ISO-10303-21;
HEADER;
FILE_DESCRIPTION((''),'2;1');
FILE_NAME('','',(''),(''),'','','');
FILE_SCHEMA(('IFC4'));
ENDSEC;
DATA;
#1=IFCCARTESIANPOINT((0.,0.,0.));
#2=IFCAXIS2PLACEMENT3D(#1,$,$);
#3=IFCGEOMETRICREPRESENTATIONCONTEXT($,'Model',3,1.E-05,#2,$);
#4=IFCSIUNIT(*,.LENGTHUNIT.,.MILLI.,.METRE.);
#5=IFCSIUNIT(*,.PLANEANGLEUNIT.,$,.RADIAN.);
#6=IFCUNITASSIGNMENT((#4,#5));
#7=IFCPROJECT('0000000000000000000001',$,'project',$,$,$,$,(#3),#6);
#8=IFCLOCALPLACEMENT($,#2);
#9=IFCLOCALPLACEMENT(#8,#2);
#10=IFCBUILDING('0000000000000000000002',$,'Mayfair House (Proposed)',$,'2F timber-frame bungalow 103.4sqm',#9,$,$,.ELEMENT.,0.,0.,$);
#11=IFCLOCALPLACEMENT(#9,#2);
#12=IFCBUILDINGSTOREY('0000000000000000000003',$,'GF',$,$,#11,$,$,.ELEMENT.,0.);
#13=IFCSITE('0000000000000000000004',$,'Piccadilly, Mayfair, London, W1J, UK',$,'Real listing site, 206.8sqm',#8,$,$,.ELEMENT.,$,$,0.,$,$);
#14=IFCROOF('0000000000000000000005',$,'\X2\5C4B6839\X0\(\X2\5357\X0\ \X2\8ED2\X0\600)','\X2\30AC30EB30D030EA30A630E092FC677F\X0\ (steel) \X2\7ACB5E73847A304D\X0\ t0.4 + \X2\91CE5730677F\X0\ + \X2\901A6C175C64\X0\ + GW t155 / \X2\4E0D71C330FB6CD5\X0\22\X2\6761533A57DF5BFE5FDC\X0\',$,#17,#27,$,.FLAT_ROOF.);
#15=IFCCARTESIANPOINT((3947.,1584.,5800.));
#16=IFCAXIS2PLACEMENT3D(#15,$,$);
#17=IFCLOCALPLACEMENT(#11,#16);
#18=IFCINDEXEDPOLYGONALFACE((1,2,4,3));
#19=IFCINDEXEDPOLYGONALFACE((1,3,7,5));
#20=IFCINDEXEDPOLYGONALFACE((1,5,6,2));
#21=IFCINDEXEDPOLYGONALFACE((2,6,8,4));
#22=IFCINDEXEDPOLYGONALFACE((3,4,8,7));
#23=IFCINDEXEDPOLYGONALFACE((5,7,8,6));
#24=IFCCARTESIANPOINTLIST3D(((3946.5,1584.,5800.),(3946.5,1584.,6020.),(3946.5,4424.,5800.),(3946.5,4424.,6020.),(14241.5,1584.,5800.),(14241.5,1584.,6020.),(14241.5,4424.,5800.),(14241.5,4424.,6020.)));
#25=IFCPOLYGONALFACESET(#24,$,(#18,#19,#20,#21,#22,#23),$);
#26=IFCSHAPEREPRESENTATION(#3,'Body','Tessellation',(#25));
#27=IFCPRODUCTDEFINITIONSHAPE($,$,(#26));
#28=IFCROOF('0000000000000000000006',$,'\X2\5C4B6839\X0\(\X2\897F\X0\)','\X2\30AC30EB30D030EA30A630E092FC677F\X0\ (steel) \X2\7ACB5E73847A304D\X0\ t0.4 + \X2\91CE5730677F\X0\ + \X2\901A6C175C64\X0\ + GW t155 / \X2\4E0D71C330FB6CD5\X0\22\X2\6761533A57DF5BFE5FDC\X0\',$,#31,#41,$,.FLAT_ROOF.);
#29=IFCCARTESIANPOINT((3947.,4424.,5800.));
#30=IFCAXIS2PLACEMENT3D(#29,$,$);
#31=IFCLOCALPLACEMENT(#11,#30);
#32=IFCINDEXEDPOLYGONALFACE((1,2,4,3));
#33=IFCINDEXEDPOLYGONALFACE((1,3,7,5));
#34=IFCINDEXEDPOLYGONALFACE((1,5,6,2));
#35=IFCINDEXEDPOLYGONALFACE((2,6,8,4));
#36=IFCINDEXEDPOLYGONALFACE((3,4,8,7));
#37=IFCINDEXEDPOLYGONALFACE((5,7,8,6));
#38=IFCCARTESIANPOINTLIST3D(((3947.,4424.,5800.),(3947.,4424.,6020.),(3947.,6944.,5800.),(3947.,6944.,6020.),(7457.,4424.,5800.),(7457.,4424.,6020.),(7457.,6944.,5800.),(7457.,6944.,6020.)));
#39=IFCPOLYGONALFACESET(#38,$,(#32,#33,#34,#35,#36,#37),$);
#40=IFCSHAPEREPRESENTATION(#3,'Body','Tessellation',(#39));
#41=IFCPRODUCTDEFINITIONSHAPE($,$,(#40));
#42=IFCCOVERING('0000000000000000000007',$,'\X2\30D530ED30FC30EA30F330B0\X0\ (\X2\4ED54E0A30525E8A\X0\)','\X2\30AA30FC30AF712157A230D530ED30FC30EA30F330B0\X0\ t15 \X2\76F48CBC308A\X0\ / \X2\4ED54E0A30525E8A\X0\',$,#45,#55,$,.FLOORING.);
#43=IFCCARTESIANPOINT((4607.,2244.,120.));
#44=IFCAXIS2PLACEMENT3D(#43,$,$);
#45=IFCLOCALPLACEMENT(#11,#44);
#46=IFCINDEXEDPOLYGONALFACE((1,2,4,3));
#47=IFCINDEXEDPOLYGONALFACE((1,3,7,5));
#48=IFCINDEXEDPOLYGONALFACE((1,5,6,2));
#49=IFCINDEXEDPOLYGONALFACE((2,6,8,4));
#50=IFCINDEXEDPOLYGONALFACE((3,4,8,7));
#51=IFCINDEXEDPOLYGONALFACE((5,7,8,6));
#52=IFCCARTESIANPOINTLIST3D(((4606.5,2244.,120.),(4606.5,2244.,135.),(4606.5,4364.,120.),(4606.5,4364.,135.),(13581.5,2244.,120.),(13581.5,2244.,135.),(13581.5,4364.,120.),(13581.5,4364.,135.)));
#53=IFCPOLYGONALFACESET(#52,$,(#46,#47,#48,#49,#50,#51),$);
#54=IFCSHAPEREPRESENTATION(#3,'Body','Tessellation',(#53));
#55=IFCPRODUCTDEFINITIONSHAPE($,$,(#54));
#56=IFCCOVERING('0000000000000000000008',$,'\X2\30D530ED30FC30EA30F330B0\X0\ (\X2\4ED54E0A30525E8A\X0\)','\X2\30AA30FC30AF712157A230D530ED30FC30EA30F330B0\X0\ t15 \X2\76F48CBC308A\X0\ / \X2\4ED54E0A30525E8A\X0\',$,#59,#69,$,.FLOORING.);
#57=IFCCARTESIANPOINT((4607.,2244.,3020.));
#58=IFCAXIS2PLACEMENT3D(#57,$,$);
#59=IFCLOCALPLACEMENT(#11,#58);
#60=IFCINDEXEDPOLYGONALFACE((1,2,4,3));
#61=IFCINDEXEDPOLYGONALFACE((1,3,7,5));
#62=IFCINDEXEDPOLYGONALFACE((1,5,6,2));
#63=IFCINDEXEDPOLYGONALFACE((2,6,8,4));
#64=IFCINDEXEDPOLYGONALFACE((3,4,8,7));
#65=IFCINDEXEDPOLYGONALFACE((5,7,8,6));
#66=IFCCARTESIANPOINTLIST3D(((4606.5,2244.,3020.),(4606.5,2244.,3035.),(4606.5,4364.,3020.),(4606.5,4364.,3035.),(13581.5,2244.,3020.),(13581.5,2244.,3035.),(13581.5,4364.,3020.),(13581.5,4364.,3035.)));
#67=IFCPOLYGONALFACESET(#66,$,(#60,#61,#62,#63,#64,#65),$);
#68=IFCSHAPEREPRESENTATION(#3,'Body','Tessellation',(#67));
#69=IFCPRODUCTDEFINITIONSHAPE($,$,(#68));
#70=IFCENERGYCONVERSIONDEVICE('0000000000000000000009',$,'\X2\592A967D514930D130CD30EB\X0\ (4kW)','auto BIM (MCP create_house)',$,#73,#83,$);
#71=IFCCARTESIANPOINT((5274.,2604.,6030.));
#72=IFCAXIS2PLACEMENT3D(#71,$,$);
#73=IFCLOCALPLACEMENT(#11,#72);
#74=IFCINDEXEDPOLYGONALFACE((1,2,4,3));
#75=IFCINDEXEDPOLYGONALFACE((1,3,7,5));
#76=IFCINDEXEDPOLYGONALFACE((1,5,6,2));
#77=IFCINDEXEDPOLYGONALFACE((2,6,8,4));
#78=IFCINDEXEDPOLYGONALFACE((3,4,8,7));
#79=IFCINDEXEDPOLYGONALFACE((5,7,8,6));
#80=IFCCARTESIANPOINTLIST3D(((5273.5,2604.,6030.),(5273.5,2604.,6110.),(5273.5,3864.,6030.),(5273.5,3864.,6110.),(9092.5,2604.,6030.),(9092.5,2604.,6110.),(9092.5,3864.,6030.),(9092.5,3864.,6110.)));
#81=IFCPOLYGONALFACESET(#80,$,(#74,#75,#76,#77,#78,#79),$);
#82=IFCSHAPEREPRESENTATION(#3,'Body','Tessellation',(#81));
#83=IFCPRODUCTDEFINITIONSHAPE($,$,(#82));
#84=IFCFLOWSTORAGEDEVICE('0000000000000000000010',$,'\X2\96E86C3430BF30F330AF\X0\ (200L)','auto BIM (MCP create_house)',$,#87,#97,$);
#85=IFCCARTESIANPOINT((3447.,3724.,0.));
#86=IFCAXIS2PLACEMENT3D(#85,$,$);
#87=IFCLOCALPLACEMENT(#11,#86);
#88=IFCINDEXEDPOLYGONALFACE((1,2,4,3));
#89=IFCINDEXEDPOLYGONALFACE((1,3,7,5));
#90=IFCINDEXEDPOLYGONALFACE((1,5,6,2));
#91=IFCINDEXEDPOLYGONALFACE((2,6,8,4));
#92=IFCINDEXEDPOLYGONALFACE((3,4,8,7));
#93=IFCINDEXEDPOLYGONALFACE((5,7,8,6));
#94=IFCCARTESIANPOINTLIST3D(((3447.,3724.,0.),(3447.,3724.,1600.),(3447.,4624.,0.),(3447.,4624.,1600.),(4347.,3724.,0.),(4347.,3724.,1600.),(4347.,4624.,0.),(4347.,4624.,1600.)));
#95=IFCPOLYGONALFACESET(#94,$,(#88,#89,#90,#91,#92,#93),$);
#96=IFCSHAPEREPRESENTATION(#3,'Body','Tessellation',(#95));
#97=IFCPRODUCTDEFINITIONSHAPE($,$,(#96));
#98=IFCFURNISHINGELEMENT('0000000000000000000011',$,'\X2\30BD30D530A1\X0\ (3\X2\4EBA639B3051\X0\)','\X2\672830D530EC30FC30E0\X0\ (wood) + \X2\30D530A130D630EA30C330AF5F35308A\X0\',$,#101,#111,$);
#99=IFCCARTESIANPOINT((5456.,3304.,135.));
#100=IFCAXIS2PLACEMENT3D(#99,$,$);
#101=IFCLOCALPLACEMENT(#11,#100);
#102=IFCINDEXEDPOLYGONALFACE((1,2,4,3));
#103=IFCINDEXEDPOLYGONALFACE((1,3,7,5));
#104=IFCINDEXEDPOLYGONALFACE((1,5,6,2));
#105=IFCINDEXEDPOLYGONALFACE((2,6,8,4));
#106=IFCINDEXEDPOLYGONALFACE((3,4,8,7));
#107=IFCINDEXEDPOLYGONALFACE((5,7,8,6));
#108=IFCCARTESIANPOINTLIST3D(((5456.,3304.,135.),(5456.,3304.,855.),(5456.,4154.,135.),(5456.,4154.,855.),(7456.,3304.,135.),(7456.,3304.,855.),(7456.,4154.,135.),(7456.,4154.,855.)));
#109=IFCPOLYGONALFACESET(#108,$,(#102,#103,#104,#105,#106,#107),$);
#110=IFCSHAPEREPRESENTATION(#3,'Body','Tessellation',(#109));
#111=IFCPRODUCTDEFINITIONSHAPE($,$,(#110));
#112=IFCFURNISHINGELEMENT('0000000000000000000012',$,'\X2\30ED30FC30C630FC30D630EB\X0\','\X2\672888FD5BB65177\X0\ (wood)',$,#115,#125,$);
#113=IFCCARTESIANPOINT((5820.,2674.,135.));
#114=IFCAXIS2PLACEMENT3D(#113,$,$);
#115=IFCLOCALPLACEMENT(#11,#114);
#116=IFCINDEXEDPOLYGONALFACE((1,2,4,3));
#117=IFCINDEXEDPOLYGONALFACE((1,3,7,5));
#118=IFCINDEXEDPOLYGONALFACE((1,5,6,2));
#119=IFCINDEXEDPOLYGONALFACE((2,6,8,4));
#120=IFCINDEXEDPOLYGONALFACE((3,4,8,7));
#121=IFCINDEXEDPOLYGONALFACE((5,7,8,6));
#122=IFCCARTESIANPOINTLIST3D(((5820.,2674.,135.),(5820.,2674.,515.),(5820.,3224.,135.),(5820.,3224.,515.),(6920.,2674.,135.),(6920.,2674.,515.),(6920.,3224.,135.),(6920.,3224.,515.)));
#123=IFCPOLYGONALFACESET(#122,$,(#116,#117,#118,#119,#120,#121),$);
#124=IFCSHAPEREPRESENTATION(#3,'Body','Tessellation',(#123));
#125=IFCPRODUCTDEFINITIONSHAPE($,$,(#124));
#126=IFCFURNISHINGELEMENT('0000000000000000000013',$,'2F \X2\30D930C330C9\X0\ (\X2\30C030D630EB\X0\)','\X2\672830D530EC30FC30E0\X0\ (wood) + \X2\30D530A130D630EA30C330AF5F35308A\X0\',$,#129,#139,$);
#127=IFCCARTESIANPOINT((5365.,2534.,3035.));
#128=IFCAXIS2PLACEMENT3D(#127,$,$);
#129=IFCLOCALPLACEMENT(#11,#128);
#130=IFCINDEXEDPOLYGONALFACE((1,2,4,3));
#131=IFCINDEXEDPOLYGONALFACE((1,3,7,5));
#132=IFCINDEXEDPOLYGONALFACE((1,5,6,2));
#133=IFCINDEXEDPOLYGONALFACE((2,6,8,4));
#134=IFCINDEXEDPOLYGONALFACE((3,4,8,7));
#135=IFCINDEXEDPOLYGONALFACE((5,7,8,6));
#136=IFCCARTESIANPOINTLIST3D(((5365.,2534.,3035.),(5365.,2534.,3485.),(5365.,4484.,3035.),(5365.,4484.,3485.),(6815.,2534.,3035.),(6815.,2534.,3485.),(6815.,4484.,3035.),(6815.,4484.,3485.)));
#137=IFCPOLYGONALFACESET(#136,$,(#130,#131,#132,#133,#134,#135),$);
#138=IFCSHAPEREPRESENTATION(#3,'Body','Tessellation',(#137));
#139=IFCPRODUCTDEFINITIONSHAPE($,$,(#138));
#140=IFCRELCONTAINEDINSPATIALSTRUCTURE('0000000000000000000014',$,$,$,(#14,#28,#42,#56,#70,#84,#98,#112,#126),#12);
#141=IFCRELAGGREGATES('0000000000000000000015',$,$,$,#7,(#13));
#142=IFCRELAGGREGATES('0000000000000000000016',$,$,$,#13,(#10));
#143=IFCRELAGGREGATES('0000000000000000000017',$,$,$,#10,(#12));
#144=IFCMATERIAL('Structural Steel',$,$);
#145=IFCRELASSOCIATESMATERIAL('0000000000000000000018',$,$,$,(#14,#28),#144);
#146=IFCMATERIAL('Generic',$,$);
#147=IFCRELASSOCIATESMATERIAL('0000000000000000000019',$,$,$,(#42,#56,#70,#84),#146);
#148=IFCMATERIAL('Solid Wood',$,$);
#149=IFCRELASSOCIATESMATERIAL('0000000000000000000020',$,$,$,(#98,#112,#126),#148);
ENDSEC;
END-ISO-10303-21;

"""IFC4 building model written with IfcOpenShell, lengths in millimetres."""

from ifc_helpers import new_model, si_unit, frame, frame_2d, origin, place, context, project, spatial, rectangle, extrude, material, element, save


model = new_model("IFC4")

# Units and contexts
model_context = context("Model", 3, precision=1e-05, world=origin())
ifc_project = project(units=[si_unit("LENGTHUNIT", "METRE", prefix="MILLI"), si_unit("PLANEANGLEUNIT", "RADIAN")], contexts=[model_context])

# Site, building, storey
site_placement = place(None, origin())
site = spatial("IfcSite", under=ifc_project, at=site_placement, Name="Piccadilly, Mayfair, London, W1J, UK", ObjectType="Real listing site, 206.8sqm", CompositionType="ELEMENT", RefElevation=0.0)
building_placement = place(site_placement, origin())
building = spatial("IfcBuilding", under=site, at=building_placement, Name="Mayfair House (Proposed)", ObjectType="2F timber-frame bungalow 103.4sqm", CompositionType="ELEMENT", ElevationOfRefHeight=0.0, ElevationOfTerrain=0.0)
storey_placement = place(building_placement, origin())
storey = spatial("IfcBuildingStorey", under=building, at=storey_placement, Name="GF", CompositionType="ELEMENT", Elevation=0.0)

# Shared definitions
ifc_material_1 = material(Name="Solid Wood")

# Roofs
ifc_material_2 = material(Name="Structural Steel")
roof_1_placement = place(storey_placement, frame((3947.0, 1584.0, 5800.0)))
element("IfcRoof", 1, at=roof_1_placement, inside=storey, material=ifc_material_2, Name="屋根(南 軒600)", Description="ガルバリウム鋼板 (steel) 立平葺き t0.4 + 野地板 + 通気層 + GW t155 / 不燃・法22条区域対応", PredefinedType="FLAT_ROOF", context=model_context, shape_type="SweptSolid", body=[
    extrude(rectangle(XDim=10295.0, YDim=2840.0, at=frame_2d((5147.0, 1420.0))), frame((3947.0, 1584.0, 5800.0)), (0.0, 0.0, 1.0), 220.0),
])
roof_2_placement = place(storey_placement, frame((3947.0, 4424.0, 5800.0)))
element("IfcRoof", 2, at=roof_2_placement, inside=storey, material=ifc_material_2, Name="屋根(西)", Description="ガルバリウム鋼板 (steel) 立平葺き t0.4 + 野地板 + 通気層 + GW t155 / 不燃・法22条区域対応", PredefinedType="FLAT_ROOF", context=model_context, shape_type="SweptSolid", body=[
    extrude(rectangle(XDim=3510.0, YDim=2520.0, at=frame_2d((1755.0, 1260.0))), frame((3947.0, 4424.0, 5800.0)), (0.0, 0.0, 1.0), 220.0),
])

# Coverings
ifc_material_3 = material(Name="Generic")
covering_1_placement = place(storey_placement, frame((4607.0, 2244.0, 120.0)))
element("IfcCovering", 3, at=covering_1_placement, inside=storey, material=ifc_material_3, Name="フローリング (仕上げ床)", Description="オーク無垢フローリング t15 直貼り / 仕上げ床", PredefinedType="FLOORING", context=model_context, shape_type="SweptSolid", body=[
    extrude(rectangle(XDim=8975.0, YDim=2120.0, at=frame_2d((4487.0, 1060.0))), frame((4607.0, 2244.0, 120.0)), (0.0, 0.0, 1.0), 15.0),
])
covering_2_placement = place(storey_placement, frame((4607.0, 2244.0, 3020.0)))
element("IfcCovering", 4, at=covering_2_placement, inside=storey, material=ifc_material_3, Name="フローリング (仕上げ床)", Description="オーク無垢フローリング t15 直貼り / 仕上げ床", PredefinedType="FLOORING", context=model_context, shape_type="SweptSolid", body=[
    extrude(rectangle(XDim=8975.0, YDim=2120.0, at=frame_2d((4487.0, 1060.0))), frame((4607.0, 2244.0, 3020.0)), (0.0, 0.0, 1.0), 15.0),
])

# Energy conversion device
energy_conversion_device_placement = place(storey_placement, frame((5274.0, 2604.0, 6030.0)))
element("IfcEnergyConversionDevice", 5, at=energy_conversion_device_placement, inside=storey, material=ifc_material_3, Name="太陽光パネル (4kW)", Description="auto BIM (MCP create_house)", context=model_context, shape_type="SweptSolid", body=[
    extrude(rectangle(XDim=3819.0, YDim=1260.0, at=frame_2d((1909.0, 630.0))), frame((5274.0, 2604.0, 6030.0)), (0.0, 0.0, 1.0), 80.0),
])

# Flow storage device
flow_storage_device_placement = place(storey_placement, frame((3447.0, 3724.0, 0.0)))
element("IfcFlowStorageDevice", 6, at=flow_storage_device_placement, inside=storey, material=ifc_material_3, Name="雨水タンク (200L)", Description="auto BIM (MCP create_house)", context=model_context, shape_type="SweptSolid", body=[
    extrude(rectangle(XDim=900.0, YDim=900.0, at=frame_2d((450.0, 450.0))), frame((3447.0, 3724.0, 0.0)), (0.0, 0.0, 1.0), 1600.0),
])

# Furnishing elements
furnishing_1_placement = place(storey_placement, frame((5456.0, 3304.0, 135.0)))
element("IfcFurnishingElement", 7, at=furnishing_1_placement, inside=storey, material=ifc_material_1, Name="ソファ (3人掛け)", Description="木フレーム (wood) + ファブリック張り", context=model_context, shape_type="SweptSolid", body=[
    extrude(rectangle(XDim=2000.0, YDim=850.0, at=frame_2d((1000.0, 425.0))), frame((5456.0, 3304.0, 135.0)), (0.0, 0.0, 1.0), 720.0),
])
furnishing_2_placement = place(storey_placement, frame((5820.0, 2674.0, 135.0)))
element("IfcFurnishingElement", 8, at=furnishing_2_placement, inside=storey, material=ifc_material_1, Name="ローテーブル", Description="木製家具 (wood)", context=model_context, shape_type="SweptSolid", body=[
    extrude(rectangle(XDim=1100.0, YDim=550.0, at=frame_2d((550.0, 275.0))), frame((5820.0, 2674.0, 135.0)), (0.0, 0.0, 1.0), 380.0),
])
furnishing_3_placement = place(storey_placement, frame((5365.0, 2534.0, 3035.0)))
element("IfcFurnishingElement", 9, at=furnishing_3_placement, inside=storey, material=ifc_material_1, Name="2F ベッド (ダブル)", Description="木フレーム (wood) + ファブリック張り", context=model_context, shape_type="SweptSolid", body=[
    extrude(rectangle(XDim=1450.0, YDim=1950.0, at=frame_2d((725.0, 975.0))), frame((5365.0, 2534.0, 3035.0)), (0.0, 0.0, 1.0), 450.0),
])

save(model, "model.ifc")
